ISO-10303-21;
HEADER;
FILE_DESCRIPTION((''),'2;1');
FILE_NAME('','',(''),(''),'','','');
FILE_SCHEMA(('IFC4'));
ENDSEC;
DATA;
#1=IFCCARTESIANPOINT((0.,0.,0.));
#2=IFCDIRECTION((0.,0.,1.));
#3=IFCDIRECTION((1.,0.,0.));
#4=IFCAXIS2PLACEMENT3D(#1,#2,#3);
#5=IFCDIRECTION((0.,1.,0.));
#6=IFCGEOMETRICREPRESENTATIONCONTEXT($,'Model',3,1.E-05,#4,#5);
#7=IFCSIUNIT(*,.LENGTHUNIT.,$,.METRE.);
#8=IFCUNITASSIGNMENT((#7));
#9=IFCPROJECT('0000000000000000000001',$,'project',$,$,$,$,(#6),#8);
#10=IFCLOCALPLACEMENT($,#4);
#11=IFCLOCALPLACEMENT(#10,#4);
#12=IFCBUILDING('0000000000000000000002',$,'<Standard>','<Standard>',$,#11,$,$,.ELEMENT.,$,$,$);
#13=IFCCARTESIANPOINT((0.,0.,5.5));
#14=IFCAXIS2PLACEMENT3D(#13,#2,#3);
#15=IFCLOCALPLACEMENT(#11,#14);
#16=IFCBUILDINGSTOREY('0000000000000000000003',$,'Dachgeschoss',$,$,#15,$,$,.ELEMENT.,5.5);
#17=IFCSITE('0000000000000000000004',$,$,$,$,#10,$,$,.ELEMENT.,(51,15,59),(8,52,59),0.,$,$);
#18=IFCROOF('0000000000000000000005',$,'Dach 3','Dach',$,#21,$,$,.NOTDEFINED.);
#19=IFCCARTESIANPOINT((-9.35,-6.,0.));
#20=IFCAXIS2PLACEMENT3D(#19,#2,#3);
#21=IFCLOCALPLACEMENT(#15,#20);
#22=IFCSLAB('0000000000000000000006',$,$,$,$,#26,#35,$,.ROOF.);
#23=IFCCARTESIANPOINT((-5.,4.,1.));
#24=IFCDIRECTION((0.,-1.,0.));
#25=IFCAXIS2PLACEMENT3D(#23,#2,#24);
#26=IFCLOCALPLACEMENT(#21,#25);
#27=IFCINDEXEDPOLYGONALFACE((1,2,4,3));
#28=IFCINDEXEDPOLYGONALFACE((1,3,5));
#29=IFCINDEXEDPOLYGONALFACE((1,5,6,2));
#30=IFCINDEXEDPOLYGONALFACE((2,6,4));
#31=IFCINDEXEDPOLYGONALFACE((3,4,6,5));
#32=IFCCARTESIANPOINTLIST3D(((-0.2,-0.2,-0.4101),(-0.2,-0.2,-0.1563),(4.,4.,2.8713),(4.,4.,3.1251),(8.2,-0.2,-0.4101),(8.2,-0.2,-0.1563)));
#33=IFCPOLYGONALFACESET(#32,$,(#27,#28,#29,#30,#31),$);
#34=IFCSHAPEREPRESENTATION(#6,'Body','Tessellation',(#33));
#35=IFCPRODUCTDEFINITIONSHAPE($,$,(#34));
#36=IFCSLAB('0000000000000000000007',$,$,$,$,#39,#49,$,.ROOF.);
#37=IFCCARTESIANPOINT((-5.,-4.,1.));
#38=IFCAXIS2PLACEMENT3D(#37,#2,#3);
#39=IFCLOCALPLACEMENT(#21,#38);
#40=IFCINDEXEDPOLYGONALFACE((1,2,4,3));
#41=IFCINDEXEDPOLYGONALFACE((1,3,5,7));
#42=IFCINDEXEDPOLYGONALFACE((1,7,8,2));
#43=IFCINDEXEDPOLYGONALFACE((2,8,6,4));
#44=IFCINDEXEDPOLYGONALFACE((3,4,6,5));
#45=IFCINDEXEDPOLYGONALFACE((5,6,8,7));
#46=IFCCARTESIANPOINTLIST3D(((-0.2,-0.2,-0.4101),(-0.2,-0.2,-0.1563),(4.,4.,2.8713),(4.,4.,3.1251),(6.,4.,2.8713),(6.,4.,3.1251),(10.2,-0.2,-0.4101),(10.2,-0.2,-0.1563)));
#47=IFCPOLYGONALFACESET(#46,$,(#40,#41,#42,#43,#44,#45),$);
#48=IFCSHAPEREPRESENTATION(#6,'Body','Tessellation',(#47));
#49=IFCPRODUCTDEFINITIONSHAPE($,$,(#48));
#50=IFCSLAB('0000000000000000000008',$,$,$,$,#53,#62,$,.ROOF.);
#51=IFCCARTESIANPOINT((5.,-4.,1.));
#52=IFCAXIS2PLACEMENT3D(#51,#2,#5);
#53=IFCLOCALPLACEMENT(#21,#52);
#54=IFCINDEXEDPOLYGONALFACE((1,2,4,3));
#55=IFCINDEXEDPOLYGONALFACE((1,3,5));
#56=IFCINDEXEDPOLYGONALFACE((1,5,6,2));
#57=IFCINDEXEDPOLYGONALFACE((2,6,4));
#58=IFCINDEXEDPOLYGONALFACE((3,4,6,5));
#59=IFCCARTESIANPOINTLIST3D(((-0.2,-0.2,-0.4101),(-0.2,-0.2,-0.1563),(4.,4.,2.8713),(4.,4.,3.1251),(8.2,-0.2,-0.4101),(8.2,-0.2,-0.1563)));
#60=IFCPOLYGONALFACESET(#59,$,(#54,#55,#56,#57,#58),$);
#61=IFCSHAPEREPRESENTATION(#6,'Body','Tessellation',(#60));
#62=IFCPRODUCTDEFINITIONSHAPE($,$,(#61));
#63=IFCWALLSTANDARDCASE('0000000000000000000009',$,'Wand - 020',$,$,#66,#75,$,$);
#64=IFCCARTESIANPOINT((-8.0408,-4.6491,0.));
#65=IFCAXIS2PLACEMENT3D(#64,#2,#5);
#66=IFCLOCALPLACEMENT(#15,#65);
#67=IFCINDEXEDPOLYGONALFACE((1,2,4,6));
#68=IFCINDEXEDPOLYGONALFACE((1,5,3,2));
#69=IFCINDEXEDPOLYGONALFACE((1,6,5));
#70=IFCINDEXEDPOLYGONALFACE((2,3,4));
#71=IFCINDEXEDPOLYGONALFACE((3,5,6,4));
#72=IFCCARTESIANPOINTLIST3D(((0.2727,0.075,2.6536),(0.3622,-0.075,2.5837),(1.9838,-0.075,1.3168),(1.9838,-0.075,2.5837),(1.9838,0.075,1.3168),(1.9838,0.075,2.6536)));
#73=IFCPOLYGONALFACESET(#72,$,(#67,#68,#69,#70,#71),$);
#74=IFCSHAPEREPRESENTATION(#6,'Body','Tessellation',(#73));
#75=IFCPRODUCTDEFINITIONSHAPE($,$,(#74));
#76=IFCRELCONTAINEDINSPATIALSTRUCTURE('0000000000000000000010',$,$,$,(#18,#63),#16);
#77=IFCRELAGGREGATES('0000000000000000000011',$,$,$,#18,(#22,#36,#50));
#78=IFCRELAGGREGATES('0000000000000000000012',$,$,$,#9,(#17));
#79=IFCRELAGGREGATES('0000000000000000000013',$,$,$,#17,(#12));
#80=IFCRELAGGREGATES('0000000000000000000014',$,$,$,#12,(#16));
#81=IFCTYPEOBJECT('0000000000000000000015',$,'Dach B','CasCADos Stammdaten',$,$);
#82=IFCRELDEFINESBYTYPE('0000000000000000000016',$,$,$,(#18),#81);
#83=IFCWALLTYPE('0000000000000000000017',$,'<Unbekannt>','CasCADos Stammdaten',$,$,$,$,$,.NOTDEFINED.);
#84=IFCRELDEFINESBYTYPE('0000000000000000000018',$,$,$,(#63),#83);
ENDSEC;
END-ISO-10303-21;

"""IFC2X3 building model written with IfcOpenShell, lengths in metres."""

from ifc_helpers import new_model, si_unit, direction, frame, origin_with_axes, place, context, project, spatial, polyline, outline, extrude, clip, bounded_halfspace, type_object, element, aggregate, save


model = new_model("IFC2X3")

# Units and contexts
model_context = context("Model", 3, precision=1e-05, world=origin_with_axes(), true_north=direction((0.0, 1.0, 0.0)))
ifc_project = project(units=[si_unit("LENGTHUNIT", "METRE")], contexts=[model_context])

# Site, building, storey
site_placement = place(None, origin_with_axes())
site = spatial("IfcSite", under=ifc_project, at=site_placement, CompositionType="ELEMENT", RefLatitude=(51, 15, 59), RefLongitude=(8, 52, 59), RefElevation=0.0)
building_placement = place(site_placement, origin_with_axes())
building = spatial("IfcBuilding", under=site, at=building_placement, Name="<Standard>", Description="<Standard>", CompositionType="ELEMENT")
storey_placement = place(building_placement, frame((0.0, 0.0, 5.5), z_axis=(0.0, 0.0, 1.0), x_axis=(1.0, 0.0, 0.0)))
storey = spatial("IfcBuildingStorey", under=building, at=storey_placement, Name="Dachgeschoss", CompositionType="ELEMENT", Elevation=5.5)

# Roof, slabs
ifc_type_object_1 = type_object("IfcTypeObject", Name="Dach B", Description="CasCADos Stammdaten")
roof_1_placement = place(storey_placement, frame((-9.35, -6.0, 0.0), z_axis=(0.0, 0.0, 1.0), x_axis=(1.0, 0.0, 0.0)))
roof_1 = element("IfcRoof", 1, at=roof_1_placement, inside=storey, type_object=ifc_type_object_1, Name="Dach 3", Description="Dach", ShapeType="NOTDEFINED")
wall_type_1 = type_object("IfcWallType", Name="<Unbekannt>", Description="CasCADos Stammdaten", PredefinedType="NOTDEFINED")
slab_1_placement = place(roof_1_placement, frame((-5.0, 4.0, 1.0), z_axis=(0.0, 0.0, 1.0), x_axis=(0.0, -1.0, 0.0)))
slab_1 = element("IfcSlab", 2, at=slab_1_placement, PredefinedType="ROOF", context=model_context, shape_type="SweptSolid", body=[
    extrude(outline(polyline([(8.2, 0.2538), (-0.2, 0.2538), (4.0, -5.0761), (8.2, 0.2538)])), frame((0.0, 0.0, 0.0), z_axis=(0.0, 0.615661, -0.788011), x_axis=(1.0, 0.0, 0.0)), (0.0, 0.615661, 0.788011), 0.2538),
])
slab_2_placement = place(roof_1_placement, frame((-5.0, -4.0, 1.0), z_axis=(0.0, 0.0, 1.0), x_axis=(1.0, 0.0, 0.0)))
slab_2 = element("IfcSlab", 3, at=slab_2_placement, PredefinedType="ROOF", context=model_context, shape_type="SweptSolid", body=[
    extrude(outline(polyline([(10.2, 0.2538), (-0.2, 0.2538), (4.0, -5.0761), (6.0, -5.0761), (10.2, 0.2538)])), frame((0.0, 0.0, 0.0), z_axis=(0.0, 0.615661, -0.788011), x_axis=(1.0, 0.0, 0.0)), (0.0, 0.615661, 0.788011), 0.2538),
])
slab_3_placement = place(roof_1_placement, frame((5.0, -4.0, 1.0), z_axis=(0.0, 0.0, 1.0), x_axis=(0.0, 1.0, 0.0)))
slab_3 = element("IfcSlab", 4, at=slab_3_placement, PredefinedType="ROOF", context=model_context, shape_type="SweptSolid", body=[
    extrude(outline(polyline([(8.2, 0.2538), (-0.2, 0.2538), (4.0, -5.0761), (8.2, 0.2538)])), frame((0.0, 0.0, 0.0), z_axis=(0.0, 0.615661, -0.788011), x_axis=(1.0, 0.0, 0.0)), (0.0, 0.615661, 0.788011), 0.2538),
])
aggregate(roof_1, [slab_1, slab_2, slab_3])

# Wall
wall_1_placement = place(storey_placement, frame((-8.0408, -4.6491, 0.0), z_axis=(0.0, 0.0, 1.0), x_axis=(0.0, 1.0, 0.0)))
element("IfcWallStandardCase", 5, at=wall_1_placement, inside=storey, type_object=wall_type_1, Name="Wand - 020", context=model_context, shape_type="Clipping", body=[
    clip(clip(extrude(outline(polyline([(0.0, 0.075), (0.0, -0.075), (1.9838, -0.075), (1.9838, 0.075), (0.0, 0.075)])), origin_with_axes(), (0.0, 0.0, 1.0), 7.8), bounded_halfspace(frame((6.946, -8.0408, -2.5601), z_axis=(0.615662, 0.0, 0.788011), x_axis=(0.0, 1.0, 0.0)), True, origin_with_axes(), polyline([(0.0, 0.075), (0.0, -0.075), (1.9838, -0.075), (1.9838, 0.075), (0.0, 0.075)]))), bounded_halfspace(frame((4.6491, -9.7143, -1.9112), z_axis=(0.0, -0.422618, 0.906308), x_axis=(1.0, 0.0, 0.0)), False, origin_with_axes(), polyline([(0.0, 0.075), (0.0, -0.075), (1.9838, -0.075), (1.9838, 0.075), (0.0, 0.075)]))),
])

save(model, "model.ifc")
